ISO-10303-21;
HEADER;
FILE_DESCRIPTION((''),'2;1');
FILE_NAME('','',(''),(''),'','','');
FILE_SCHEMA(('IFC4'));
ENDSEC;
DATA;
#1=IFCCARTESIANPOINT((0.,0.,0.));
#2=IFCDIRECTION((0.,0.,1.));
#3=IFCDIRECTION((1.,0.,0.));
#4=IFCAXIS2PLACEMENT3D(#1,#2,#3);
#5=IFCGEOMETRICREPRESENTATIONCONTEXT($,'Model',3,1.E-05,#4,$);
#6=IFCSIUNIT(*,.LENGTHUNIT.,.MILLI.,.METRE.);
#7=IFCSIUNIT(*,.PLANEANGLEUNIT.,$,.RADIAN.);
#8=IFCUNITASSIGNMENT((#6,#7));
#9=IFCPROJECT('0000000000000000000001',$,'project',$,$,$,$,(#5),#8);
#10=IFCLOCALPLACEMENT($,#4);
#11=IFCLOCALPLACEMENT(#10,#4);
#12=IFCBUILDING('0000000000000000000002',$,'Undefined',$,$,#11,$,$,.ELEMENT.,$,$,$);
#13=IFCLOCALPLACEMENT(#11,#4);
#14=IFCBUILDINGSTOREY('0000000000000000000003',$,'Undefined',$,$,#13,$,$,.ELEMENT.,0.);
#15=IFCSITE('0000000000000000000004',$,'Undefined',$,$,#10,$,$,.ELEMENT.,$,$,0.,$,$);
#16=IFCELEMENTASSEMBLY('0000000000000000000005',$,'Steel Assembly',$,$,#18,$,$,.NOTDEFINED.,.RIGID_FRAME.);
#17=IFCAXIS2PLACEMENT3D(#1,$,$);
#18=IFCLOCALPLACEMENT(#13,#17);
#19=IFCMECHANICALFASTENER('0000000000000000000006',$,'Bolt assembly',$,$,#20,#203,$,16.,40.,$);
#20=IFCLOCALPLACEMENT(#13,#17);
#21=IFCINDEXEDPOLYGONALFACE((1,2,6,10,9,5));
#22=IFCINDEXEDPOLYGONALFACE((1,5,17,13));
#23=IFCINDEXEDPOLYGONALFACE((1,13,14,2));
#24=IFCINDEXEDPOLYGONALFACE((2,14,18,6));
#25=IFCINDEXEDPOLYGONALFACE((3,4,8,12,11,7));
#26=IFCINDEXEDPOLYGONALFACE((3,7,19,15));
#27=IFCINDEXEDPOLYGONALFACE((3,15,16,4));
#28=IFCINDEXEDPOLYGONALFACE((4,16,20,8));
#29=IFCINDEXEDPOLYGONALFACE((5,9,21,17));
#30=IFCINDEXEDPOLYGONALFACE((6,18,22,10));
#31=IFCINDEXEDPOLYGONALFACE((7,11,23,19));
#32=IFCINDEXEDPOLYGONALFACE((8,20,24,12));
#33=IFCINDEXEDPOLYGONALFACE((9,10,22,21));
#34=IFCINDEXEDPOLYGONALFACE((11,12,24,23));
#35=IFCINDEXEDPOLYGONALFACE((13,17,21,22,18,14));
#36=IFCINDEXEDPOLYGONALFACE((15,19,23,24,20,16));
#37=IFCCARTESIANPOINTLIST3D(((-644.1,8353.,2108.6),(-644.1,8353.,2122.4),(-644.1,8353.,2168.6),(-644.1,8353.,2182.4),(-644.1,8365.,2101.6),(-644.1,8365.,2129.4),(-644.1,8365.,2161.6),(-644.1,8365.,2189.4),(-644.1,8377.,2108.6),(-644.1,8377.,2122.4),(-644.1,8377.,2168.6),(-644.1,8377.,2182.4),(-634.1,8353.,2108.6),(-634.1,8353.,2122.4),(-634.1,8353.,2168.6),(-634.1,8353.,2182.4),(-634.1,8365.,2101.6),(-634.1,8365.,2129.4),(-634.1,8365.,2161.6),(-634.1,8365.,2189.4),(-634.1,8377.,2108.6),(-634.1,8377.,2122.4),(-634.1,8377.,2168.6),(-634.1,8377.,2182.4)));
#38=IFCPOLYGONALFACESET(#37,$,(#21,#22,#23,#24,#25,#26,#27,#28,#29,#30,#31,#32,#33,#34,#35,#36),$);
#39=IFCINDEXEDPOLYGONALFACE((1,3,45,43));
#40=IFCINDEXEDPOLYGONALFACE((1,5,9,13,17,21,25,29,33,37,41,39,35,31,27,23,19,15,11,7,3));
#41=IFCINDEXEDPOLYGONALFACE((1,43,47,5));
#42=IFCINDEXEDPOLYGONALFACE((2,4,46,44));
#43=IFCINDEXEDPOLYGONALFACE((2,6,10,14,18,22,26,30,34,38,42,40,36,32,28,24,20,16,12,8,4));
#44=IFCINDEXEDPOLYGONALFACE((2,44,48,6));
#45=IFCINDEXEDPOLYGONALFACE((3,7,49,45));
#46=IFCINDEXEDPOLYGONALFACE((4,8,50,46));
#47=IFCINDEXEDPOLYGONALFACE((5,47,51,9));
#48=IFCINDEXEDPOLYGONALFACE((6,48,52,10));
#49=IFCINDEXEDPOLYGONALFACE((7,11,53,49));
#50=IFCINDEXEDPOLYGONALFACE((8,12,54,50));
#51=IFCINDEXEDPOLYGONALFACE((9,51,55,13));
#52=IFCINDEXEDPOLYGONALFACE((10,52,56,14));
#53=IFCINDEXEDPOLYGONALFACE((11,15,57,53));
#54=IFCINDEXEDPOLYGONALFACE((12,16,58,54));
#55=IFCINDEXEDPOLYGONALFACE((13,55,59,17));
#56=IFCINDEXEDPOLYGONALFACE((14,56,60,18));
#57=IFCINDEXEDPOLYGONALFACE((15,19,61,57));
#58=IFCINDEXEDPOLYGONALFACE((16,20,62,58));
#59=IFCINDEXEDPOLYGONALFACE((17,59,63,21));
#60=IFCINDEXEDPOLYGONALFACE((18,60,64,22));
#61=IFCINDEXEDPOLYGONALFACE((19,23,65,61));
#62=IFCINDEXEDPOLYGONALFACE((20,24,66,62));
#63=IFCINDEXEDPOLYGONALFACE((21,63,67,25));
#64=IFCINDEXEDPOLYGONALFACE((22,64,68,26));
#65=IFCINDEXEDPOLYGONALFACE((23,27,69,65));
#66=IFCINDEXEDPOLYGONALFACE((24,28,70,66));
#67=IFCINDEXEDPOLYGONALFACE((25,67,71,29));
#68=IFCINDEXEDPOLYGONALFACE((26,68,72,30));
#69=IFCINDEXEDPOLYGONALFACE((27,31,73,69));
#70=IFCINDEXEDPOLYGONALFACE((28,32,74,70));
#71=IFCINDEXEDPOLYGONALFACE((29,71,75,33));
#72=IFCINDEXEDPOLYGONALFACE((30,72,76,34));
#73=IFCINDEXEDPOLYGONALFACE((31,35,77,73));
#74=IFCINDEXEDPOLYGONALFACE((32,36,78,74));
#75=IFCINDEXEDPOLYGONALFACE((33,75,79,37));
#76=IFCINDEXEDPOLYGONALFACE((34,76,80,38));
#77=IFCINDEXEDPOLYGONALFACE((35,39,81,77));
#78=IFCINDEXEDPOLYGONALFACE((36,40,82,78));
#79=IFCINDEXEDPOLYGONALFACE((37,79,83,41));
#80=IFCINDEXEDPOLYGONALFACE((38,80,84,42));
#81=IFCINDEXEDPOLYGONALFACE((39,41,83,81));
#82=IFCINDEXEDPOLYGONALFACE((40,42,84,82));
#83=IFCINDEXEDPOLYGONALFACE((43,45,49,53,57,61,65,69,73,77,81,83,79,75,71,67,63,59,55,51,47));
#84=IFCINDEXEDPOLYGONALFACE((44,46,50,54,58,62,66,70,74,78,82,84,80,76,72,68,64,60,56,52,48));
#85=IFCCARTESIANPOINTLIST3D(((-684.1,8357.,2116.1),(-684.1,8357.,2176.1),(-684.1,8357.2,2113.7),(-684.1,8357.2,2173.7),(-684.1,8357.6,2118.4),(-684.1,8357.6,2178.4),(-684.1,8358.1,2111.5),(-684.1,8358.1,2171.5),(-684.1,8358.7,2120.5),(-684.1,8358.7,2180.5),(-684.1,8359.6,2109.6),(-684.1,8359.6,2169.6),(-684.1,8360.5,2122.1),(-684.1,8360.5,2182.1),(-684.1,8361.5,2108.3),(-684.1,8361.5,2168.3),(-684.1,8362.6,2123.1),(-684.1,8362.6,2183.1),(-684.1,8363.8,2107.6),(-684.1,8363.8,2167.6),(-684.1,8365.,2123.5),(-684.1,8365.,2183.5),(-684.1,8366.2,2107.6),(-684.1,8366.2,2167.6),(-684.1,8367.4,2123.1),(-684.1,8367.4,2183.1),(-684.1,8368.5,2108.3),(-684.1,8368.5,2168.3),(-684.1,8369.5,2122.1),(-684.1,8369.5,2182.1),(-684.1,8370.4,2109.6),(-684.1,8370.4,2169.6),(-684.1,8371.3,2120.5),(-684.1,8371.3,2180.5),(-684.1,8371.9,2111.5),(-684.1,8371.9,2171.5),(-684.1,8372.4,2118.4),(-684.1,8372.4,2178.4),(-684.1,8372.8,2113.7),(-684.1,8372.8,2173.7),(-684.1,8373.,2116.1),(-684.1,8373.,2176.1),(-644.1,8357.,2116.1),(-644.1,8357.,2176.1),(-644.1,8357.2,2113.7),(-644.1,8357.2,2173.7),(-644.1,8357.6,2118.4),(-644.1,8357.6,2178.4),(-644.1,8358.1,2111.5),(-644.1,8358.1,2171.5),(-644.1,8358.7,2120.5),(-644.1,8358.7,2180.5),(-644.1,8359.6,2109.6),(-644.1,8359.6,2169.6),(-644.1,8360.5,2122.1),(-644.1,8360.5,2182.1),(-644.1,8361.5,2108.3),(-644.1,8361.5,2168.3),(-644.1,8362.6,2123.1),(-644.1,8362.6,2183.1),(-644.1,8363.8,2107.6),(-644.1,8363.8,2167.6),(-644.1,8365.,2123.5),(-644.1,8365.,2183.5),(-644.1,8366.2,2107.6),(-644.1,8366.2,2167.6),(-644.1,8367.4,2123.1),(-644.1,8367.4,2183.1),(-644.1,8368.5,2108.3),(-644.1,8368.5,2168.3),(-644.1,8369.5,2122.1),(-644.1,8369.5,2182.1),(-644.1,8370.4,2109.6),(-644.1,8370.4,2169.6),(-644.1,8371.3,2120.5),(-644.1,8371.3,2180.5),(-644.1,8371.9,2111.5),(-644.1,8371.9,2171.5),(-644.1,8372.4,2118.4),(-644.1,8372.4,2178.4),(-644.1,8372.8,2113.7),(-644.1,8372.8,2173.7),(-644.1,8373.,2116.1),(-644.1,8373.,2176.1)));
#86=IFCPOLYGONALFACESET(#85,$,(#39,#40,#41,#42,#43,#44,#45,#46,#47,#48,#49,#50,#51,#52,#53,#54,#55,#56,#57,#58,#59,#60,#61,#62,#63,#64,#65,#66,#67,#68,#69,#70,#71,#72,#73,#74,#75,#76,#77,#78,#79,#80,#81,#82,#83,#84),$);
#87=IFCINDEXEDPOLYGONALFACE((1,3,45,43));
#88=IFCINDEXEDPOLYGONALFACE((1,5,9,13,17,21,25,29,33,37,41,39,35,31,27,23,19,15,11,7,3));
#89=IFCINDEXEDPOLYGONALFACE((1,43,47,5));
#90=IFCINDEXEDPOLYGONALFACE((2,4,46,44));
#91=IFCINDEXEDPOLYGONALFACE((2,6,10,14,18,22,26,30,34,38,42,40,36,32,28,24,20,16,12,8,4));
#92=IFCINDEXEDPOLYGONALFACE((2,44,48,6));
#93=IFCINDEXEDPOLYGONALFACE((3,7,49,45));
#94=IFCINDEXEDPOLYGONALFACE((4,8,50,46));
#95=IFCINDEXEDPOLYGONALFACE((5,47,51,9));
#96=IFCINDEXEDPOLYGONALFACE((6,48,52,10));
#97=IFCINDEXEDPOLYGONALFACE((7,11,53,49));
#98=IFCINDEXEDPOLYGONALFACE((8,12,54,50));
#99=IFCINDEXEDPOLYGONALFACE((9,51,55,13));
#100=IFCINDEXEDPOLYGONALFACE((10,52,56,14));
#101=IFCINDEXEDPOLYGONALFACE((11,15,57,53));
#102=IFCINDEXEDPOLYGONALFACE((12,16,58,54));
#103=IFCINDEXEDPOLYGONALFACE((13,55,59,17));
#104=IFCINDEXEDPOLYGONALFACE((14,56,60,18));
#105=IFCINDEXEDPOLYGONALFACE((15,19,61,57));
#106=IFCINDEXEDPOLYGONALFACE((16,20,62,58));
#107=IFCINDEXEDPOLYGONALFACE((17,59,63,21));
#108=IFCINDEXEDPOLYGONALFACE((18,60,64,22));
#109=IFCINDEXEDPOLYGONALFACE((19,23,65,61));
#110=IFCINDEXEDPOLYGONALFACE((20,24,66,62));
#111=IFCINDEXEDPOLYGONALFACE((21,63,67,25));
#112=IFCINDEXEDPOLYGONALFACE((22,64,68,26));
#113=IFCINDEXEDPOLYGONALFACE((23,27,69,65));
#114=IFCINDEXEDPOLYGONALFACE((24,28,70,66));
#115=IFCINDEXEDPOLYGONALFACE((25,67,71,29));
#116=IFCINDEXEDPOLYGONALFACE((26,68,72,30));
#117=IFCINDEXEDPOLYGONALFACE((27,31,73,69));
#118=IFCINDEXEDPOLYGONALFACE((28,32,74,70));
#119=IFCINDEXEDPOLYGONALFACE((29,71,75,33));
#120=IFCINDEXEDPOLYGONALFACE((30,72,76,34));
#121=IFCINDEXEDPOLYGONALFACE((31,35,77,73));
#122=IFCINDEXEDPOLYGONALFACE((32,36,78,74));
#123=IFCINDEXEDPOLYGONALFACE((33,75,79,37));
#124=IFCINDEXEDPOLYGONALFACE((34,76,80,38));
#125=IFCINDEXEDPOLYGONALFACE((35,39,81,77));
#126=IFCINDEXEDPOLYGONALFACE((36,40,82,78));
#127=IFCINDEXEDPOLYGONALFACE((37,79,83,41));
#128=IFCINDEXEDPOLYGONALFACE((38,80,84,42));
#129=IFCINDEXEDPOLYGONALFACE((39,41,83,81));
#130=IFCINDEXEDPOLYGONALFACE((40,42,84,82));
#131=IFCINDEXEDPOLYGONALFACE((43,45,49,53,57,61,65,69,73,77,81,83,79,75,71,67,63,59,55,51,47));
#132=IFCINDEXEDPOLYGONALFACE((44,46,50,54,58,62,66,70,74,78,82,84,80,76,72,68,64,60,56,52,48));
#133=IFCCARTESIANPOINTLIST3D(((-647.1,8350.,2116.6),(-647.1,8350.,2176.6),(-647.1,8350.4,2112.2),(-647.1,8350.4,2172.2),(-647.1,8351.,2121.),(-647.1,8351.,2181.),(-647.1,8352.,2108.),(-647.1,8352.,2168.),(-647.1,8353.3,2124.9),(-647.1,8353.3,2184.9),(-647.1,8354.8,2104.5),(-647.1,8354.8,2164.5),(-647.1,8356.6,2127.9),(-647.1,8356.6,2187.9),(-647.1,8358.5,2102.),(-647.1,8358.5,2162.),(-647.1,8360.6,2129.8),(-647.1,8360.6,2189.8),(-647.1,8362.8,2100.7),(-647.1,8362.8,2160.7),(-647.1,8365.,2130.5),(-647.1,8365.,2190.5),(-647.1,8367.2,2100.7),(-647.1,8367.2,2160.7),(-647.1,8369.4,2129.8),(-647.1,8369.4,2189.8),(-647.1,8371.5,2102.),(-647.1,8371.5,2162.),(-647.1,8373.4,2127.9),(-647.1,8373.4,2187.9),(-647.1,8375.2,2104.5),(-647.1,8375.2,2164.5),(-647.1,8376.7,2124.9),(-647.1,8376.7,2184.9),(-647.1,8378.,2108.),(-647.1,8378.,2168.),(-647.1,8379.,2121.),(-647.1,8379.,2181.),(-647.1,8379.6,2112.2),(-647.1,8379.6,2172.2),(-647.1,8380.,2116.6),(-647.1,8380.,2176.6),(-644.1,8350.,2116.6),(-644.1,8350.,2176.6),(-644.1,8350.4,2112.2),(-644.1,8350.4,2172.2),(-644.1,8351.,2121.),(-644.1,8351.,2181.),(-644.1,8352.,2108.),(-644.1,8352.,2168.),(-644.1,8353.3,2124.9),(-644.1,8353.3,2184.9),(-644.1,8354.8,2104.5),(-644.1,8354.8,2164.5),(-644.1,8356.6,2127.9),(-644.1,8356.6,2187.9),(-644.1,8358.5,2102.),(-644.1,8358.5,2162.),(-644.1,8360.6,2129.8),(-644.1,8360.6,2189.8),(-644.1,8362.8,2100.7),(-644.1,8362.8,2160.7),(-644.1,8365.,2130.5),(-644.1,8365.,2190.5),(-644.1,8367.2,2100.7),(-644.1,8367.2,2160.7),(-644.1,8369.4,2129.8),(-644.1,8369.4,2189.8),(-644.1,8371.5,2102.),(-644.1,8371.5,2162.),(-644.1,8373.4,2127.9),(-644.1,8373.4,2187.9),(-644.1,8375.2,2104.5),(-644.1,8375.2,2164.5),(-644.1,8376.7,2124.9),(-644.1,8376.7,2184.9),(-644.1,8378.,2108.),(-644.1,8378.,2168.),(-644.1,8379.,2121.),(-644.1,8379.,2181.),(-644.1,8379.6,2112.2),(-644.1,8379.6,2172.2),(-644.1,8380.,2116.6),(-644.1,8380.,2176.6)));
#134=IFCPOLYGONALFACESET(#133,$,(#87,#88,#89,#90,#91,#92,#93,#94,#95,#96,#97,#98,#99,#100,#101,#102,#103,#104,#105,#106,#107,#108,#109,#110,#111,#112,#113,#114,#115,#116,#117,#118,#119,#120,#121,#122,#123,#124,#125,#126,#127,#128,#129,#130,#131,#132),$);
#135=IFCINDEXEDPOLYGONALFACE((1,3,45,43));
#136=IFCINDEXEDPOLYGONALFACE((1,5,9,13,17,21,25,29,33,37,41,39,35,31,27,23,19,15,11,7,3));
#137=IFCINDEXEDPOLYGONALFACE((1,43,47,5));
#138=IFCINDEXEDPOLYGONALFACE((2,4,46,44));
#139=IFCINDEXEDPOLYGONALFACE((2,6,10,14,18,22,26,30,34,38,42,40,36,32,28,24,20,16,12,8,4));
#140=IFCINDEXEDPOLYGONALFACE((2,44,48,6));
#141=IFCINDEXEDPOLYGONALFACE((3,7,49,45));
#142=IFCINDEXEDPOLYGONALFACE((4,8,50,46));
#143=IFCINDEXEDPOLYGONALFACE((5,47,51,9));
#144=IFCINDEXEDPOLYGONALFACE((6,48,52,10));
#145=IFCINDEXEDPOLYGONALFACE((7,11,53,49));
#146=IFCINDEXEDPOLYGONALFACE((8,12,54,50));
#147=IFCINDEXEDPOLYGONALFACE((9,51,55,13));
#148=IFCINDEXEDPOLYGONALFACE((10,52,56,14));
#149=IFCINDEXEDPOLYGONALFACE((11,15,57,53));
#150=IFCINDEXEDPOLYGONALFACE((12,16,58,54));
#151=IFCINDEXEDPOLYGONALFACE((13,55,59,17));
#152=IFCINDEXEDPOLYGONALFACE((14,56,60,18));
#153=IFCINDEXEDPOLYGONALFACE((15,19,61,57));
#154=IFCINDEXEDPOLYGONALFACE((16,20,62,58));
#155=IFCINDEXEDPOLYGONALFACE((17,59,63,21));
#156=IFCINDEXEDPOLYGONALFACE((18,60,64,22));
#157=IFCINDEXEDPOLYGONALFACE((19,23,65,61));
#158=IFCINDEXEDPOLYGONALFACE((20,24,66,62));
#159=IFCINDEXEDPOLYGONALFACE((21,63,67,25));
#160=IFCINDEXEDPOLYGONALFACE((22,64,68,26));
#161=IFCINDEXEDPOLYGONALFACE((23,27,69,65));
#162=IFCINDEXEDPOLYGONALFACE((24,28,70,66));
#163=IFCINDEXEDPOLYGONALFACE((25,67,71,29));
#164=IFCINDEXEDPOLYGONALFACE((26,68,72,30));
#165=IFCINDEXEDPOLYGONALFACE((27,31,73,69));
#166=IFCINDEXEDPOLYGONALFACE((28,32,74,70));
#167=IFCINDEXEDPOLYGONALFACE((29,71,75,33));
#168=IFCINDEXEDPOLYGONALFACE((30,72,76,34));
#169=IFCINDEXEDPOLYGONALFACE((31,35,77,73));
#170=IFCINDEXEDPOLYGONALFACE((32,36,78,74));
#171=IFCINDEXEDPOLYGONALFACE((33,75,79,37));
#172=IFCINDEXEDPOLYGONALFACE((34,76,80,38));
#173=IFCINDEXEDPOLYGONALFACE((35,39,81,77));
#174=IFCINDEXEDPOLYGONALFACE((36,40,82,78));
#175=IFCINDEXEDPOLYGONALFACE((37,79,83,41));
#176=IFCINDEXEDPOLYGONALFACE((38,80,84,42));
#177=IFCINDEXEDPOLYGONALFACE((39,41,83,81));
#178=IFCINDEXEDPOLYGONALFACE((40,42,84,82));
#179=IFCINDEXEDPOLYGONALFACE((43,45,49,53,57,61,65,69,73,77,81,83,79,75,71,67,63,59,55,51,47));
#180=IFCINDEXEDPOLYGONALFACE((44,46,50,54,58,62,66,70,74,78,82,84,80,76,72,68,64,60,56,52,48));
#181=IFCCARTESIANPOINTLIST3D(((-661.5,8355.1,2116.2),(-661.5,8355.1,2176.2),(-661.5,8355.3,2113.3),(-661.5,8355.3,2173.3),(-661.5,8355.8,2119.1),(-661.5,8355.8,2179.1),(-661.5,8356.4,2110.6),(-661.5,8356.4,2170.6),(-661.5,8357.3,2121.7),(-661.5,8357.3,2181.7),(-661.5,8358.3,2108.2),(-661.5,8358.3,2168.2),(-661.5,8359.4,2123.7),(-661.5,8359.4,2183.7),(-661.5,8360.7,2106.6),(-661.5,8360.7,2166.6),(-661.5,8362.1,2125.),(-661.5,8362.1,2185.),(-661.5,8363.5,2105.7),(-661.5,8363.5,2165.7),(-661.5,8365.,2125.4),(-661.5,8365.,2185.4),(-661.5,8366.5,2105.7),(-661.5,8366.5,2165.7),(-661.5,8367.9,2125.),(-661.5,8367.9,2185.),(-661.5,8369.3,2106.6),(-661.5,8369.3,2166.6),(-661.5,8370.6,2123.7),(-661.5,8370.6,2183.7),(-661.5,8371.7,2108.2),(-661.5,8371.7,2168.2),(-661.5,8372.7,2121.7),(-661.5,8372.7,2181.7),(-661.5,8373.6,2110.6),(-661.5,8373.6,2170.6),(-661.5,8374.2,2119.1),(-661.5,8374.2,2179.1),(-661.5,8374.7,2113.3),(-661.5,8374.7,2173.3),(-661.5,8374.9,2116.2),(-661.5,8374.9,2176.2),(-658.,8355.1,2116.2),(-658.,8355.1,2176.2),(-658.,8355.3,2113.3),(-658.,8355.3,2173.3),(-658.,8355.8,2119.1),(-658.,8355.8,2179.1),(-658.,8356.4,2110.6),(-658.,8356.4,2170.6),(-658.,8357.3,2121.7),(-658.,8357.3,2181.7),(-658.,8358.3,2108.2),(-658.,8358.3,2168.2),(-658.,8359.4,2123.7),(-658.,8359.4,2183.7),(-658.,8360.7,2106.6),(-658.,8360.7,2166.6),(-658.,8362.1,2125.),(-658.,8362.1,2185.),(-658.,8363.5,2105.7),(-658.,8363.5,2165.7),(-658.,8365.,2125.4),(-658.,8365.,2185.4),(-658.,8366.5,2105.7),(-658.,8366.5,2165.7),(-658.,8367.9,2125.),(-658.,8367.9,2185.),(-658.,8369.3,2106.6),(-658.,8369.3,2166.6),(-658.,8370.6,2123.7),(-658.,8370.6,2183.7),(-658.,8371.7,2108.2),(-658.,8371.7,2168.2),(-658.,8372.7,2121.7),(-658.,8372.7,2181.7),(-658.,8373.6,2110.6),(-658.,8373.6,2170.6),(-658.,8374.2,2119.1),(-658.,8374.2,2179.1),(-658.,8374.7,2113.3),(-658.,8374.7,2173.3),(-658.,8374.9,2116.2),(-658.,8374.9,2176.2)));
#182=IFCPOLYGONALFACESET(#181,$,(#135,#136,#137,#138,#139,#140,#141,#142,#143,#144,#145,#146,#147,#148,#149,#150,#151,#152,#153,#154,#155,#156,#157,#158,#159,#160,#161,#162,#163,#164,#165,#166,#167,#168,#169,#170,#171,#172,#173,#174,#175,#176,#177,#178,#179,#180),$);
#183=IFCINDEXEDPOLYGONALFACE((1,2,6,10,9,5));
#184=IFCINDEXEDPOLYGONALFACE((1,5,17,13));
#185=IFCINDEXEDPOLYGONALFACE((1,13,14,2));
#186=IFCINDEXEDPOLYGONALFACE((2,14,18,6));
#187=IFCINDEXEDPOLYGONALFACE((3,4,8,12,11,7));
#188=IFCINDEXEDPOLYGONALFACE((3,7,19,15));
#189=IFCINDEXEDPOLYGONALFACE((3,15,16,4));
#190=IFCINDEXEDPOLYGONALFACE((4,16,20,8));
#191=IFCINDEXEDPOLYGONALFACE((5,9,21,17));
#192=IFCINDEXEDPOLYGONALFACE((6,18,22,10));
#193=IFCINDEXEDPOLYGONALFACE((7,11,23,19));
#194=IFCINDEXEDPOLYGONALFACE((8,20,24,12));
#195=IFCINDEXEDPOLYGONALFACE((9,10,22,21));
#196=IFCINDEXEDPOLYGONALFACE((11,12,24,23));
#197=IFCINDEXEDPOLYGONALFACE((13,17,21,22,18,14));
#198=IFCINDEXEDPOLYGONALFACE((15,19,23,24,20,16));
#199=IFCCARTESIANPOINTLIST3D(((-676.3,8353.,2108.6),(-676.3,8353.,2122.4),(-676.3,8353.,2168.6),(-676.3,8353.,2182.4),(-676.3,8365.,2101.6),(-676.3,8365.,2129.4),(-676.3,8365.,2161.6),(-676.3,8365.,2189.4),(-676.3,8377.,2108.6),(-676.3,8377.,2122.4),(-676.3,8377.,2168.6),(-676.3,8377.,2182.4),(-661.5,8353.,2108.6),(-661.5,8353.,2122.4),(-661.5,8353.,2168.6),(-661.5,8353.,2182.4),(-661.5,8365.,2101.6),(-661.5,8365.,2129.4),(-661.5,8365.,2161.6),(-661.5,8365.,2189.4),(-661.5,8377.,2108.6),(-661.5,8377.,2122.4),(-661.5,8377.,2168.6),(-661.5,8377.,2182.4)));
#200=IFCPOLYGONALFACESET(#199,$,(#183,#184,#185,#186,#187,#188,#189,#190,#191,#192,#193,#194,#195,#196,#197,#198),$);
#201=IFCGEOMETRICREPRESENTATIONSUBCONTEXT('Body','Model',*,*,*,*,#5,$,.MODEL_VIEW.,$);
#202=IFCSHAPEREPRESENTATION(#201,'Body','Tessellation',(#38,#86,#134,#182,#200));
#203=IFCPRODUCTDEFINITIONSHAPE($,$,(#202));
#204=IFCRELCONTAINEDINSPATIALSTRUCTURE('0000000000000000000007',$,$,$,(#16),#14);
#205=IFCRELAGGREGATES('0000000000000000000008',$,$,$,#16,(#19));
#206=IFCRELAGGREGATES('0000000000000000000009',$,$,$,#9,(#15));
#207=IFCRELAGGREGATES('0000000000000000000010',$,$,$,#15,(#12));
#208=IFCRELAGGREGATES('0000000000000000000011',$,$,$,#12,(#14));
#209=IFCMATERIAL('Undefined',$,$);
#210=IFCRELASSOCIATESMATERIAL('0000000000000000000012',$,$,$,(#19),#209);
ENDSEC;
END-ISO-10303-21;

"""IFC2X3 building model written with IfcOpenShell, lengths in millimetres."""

from ifc_helpers import new_model, si_unit, frame, origin_with_axes, origin_2d_with_axis, place, context, subcontext, project, spatial, polyline, circle, outline, extrude, source, transform, mapped, material, element, aggregate, save


model = new_model("IFC2X3")

# Units and contexts
model_context = context("Model", 3, precision=1e-05, world=origin_with_axes())
body_context = subcontext(model_context, "Body", "Model", "MODEL_VIEW")
ifc_project = project(units=[si_unit("LENGTHUNIT", "METRE", prefix="MILLI"), si_unit("PLANEANGLEUNIT", "RADIAN")], contexts=[model_context])

# Site, building, storey
site_placement = place(None, origin_with_axes())
site = spatial("IfcSite", under=ifc_project, at=site_placement, Name="Undefined", CompositionType="ELEMENT", RefElevation=0.0)
building_placement = place(site_placement, origin_with_axes())
building = spatial("IfcBuilding", under=site, at=building_placement, Name="Undefined", CompositionType="ELEMENT")
storey_placement = place(building_placement, origin_with_axes())
storey = spatial("IfcBuildingStorey", under=building, at=storey_placement, Name="Undefined", CompositionType="ELEMENT", Elevation=0.0)

# Element assembly, mechanical fastener
assembly_1_placement = place(storey_placement, origin_with_axes())
assembly_1 = element("IfcElementAssembly", 1, at=assembly_1_placement, inside=storey, Name="Steel Assembly", AssemblyPlace="NOTDEFINED", PredefinedType="RIGID_FRAME")
ifc_material_1 = material(Name="Undefined")
shared_shape_1 = source(origin_with_axes(), body_context, "Body", "SweptSolid", [
    extrude(outline(polyline([(13.9, 0.0), (6.9, 12.0), (-6.9, 12.0), (-13.9, 0.0), (-6.9, -12.0), (6.9, -12.0), (13.9, 0.0)])), frame((0.0, -17.9, 0.0), z_axis=(0.0, 1.0, 0.0), x_axis=(1.0, 0.0, 0.0)), (0.0, 0.0, 1.0), 10.0),
    extrude(circle(Radius=8.0, at=origin_2d_with_axis()), frame((0.0, -7.9, 0.0), z_axis=(0.0, 1.0, 0.0), x_axis=(1.0, 0.0, 0.0)), (0.0, 0.0, 1.0), 40.0),
    extrude(circle(Radius=15.0, at=origin_2d_with_axis()), frame((0.0, -7.9, 0.0), z_axis=(0.0, 1.0, 0.0), x_axis=(1.0, 0.0, 0.0)), (0.0, 0.0, 1.0), 3.0),
    extrude(circle(Radius=9.9, at=origin_2d_with_axis()), frame((0.0, 6.0, 0.0), z_axis=(0.0, 1.0, 0.0), x_axis=(1.0, 0.0, 0.0)), (0.0, 0.0, 1.0), 3.5),
    extrude(outline(polyline([(13.9, 0.0), (6.9, 12.0), (-6.9, 12.0), (-13.9, 0.0), (-6.9, -12.0), (6.9, -12.0), (13.9, 0.0)])), frame((0.0, 9.5, 0.0), z_axis=(0.0, 1.0, 0.0), x_axis=(1.0, 0.0, 0.0)), (0.0, 0.0, 1.0), 14.8),
])
mechanical_fastener_placement = place(assembly_1_placement, frame((-652.0, 8365.0, 2115.5), z_axis=(0.0, -1.0, 0.0), x_axis=(0.0, 0.0, 1.0)))
mechanical_fastener = element("IfcMechanicalFastener", 2, at=mechanical_fastener_placement, material=ifc_material_1, Name="Bolt assembly", NominalDiameter=16.0, NominalLength=40.0, context=body_context, shape_type="MappedRepresentation", body=[
    mapped(shared_shape_1, transform((0.0, 0.0, 0.0))),
    mapped(shared_shape_1, transform((60.0, 0.0, 0.0))),
])
aggregate(assembly_1, [mechanical_fastener])

save(model, "model.ifc")
